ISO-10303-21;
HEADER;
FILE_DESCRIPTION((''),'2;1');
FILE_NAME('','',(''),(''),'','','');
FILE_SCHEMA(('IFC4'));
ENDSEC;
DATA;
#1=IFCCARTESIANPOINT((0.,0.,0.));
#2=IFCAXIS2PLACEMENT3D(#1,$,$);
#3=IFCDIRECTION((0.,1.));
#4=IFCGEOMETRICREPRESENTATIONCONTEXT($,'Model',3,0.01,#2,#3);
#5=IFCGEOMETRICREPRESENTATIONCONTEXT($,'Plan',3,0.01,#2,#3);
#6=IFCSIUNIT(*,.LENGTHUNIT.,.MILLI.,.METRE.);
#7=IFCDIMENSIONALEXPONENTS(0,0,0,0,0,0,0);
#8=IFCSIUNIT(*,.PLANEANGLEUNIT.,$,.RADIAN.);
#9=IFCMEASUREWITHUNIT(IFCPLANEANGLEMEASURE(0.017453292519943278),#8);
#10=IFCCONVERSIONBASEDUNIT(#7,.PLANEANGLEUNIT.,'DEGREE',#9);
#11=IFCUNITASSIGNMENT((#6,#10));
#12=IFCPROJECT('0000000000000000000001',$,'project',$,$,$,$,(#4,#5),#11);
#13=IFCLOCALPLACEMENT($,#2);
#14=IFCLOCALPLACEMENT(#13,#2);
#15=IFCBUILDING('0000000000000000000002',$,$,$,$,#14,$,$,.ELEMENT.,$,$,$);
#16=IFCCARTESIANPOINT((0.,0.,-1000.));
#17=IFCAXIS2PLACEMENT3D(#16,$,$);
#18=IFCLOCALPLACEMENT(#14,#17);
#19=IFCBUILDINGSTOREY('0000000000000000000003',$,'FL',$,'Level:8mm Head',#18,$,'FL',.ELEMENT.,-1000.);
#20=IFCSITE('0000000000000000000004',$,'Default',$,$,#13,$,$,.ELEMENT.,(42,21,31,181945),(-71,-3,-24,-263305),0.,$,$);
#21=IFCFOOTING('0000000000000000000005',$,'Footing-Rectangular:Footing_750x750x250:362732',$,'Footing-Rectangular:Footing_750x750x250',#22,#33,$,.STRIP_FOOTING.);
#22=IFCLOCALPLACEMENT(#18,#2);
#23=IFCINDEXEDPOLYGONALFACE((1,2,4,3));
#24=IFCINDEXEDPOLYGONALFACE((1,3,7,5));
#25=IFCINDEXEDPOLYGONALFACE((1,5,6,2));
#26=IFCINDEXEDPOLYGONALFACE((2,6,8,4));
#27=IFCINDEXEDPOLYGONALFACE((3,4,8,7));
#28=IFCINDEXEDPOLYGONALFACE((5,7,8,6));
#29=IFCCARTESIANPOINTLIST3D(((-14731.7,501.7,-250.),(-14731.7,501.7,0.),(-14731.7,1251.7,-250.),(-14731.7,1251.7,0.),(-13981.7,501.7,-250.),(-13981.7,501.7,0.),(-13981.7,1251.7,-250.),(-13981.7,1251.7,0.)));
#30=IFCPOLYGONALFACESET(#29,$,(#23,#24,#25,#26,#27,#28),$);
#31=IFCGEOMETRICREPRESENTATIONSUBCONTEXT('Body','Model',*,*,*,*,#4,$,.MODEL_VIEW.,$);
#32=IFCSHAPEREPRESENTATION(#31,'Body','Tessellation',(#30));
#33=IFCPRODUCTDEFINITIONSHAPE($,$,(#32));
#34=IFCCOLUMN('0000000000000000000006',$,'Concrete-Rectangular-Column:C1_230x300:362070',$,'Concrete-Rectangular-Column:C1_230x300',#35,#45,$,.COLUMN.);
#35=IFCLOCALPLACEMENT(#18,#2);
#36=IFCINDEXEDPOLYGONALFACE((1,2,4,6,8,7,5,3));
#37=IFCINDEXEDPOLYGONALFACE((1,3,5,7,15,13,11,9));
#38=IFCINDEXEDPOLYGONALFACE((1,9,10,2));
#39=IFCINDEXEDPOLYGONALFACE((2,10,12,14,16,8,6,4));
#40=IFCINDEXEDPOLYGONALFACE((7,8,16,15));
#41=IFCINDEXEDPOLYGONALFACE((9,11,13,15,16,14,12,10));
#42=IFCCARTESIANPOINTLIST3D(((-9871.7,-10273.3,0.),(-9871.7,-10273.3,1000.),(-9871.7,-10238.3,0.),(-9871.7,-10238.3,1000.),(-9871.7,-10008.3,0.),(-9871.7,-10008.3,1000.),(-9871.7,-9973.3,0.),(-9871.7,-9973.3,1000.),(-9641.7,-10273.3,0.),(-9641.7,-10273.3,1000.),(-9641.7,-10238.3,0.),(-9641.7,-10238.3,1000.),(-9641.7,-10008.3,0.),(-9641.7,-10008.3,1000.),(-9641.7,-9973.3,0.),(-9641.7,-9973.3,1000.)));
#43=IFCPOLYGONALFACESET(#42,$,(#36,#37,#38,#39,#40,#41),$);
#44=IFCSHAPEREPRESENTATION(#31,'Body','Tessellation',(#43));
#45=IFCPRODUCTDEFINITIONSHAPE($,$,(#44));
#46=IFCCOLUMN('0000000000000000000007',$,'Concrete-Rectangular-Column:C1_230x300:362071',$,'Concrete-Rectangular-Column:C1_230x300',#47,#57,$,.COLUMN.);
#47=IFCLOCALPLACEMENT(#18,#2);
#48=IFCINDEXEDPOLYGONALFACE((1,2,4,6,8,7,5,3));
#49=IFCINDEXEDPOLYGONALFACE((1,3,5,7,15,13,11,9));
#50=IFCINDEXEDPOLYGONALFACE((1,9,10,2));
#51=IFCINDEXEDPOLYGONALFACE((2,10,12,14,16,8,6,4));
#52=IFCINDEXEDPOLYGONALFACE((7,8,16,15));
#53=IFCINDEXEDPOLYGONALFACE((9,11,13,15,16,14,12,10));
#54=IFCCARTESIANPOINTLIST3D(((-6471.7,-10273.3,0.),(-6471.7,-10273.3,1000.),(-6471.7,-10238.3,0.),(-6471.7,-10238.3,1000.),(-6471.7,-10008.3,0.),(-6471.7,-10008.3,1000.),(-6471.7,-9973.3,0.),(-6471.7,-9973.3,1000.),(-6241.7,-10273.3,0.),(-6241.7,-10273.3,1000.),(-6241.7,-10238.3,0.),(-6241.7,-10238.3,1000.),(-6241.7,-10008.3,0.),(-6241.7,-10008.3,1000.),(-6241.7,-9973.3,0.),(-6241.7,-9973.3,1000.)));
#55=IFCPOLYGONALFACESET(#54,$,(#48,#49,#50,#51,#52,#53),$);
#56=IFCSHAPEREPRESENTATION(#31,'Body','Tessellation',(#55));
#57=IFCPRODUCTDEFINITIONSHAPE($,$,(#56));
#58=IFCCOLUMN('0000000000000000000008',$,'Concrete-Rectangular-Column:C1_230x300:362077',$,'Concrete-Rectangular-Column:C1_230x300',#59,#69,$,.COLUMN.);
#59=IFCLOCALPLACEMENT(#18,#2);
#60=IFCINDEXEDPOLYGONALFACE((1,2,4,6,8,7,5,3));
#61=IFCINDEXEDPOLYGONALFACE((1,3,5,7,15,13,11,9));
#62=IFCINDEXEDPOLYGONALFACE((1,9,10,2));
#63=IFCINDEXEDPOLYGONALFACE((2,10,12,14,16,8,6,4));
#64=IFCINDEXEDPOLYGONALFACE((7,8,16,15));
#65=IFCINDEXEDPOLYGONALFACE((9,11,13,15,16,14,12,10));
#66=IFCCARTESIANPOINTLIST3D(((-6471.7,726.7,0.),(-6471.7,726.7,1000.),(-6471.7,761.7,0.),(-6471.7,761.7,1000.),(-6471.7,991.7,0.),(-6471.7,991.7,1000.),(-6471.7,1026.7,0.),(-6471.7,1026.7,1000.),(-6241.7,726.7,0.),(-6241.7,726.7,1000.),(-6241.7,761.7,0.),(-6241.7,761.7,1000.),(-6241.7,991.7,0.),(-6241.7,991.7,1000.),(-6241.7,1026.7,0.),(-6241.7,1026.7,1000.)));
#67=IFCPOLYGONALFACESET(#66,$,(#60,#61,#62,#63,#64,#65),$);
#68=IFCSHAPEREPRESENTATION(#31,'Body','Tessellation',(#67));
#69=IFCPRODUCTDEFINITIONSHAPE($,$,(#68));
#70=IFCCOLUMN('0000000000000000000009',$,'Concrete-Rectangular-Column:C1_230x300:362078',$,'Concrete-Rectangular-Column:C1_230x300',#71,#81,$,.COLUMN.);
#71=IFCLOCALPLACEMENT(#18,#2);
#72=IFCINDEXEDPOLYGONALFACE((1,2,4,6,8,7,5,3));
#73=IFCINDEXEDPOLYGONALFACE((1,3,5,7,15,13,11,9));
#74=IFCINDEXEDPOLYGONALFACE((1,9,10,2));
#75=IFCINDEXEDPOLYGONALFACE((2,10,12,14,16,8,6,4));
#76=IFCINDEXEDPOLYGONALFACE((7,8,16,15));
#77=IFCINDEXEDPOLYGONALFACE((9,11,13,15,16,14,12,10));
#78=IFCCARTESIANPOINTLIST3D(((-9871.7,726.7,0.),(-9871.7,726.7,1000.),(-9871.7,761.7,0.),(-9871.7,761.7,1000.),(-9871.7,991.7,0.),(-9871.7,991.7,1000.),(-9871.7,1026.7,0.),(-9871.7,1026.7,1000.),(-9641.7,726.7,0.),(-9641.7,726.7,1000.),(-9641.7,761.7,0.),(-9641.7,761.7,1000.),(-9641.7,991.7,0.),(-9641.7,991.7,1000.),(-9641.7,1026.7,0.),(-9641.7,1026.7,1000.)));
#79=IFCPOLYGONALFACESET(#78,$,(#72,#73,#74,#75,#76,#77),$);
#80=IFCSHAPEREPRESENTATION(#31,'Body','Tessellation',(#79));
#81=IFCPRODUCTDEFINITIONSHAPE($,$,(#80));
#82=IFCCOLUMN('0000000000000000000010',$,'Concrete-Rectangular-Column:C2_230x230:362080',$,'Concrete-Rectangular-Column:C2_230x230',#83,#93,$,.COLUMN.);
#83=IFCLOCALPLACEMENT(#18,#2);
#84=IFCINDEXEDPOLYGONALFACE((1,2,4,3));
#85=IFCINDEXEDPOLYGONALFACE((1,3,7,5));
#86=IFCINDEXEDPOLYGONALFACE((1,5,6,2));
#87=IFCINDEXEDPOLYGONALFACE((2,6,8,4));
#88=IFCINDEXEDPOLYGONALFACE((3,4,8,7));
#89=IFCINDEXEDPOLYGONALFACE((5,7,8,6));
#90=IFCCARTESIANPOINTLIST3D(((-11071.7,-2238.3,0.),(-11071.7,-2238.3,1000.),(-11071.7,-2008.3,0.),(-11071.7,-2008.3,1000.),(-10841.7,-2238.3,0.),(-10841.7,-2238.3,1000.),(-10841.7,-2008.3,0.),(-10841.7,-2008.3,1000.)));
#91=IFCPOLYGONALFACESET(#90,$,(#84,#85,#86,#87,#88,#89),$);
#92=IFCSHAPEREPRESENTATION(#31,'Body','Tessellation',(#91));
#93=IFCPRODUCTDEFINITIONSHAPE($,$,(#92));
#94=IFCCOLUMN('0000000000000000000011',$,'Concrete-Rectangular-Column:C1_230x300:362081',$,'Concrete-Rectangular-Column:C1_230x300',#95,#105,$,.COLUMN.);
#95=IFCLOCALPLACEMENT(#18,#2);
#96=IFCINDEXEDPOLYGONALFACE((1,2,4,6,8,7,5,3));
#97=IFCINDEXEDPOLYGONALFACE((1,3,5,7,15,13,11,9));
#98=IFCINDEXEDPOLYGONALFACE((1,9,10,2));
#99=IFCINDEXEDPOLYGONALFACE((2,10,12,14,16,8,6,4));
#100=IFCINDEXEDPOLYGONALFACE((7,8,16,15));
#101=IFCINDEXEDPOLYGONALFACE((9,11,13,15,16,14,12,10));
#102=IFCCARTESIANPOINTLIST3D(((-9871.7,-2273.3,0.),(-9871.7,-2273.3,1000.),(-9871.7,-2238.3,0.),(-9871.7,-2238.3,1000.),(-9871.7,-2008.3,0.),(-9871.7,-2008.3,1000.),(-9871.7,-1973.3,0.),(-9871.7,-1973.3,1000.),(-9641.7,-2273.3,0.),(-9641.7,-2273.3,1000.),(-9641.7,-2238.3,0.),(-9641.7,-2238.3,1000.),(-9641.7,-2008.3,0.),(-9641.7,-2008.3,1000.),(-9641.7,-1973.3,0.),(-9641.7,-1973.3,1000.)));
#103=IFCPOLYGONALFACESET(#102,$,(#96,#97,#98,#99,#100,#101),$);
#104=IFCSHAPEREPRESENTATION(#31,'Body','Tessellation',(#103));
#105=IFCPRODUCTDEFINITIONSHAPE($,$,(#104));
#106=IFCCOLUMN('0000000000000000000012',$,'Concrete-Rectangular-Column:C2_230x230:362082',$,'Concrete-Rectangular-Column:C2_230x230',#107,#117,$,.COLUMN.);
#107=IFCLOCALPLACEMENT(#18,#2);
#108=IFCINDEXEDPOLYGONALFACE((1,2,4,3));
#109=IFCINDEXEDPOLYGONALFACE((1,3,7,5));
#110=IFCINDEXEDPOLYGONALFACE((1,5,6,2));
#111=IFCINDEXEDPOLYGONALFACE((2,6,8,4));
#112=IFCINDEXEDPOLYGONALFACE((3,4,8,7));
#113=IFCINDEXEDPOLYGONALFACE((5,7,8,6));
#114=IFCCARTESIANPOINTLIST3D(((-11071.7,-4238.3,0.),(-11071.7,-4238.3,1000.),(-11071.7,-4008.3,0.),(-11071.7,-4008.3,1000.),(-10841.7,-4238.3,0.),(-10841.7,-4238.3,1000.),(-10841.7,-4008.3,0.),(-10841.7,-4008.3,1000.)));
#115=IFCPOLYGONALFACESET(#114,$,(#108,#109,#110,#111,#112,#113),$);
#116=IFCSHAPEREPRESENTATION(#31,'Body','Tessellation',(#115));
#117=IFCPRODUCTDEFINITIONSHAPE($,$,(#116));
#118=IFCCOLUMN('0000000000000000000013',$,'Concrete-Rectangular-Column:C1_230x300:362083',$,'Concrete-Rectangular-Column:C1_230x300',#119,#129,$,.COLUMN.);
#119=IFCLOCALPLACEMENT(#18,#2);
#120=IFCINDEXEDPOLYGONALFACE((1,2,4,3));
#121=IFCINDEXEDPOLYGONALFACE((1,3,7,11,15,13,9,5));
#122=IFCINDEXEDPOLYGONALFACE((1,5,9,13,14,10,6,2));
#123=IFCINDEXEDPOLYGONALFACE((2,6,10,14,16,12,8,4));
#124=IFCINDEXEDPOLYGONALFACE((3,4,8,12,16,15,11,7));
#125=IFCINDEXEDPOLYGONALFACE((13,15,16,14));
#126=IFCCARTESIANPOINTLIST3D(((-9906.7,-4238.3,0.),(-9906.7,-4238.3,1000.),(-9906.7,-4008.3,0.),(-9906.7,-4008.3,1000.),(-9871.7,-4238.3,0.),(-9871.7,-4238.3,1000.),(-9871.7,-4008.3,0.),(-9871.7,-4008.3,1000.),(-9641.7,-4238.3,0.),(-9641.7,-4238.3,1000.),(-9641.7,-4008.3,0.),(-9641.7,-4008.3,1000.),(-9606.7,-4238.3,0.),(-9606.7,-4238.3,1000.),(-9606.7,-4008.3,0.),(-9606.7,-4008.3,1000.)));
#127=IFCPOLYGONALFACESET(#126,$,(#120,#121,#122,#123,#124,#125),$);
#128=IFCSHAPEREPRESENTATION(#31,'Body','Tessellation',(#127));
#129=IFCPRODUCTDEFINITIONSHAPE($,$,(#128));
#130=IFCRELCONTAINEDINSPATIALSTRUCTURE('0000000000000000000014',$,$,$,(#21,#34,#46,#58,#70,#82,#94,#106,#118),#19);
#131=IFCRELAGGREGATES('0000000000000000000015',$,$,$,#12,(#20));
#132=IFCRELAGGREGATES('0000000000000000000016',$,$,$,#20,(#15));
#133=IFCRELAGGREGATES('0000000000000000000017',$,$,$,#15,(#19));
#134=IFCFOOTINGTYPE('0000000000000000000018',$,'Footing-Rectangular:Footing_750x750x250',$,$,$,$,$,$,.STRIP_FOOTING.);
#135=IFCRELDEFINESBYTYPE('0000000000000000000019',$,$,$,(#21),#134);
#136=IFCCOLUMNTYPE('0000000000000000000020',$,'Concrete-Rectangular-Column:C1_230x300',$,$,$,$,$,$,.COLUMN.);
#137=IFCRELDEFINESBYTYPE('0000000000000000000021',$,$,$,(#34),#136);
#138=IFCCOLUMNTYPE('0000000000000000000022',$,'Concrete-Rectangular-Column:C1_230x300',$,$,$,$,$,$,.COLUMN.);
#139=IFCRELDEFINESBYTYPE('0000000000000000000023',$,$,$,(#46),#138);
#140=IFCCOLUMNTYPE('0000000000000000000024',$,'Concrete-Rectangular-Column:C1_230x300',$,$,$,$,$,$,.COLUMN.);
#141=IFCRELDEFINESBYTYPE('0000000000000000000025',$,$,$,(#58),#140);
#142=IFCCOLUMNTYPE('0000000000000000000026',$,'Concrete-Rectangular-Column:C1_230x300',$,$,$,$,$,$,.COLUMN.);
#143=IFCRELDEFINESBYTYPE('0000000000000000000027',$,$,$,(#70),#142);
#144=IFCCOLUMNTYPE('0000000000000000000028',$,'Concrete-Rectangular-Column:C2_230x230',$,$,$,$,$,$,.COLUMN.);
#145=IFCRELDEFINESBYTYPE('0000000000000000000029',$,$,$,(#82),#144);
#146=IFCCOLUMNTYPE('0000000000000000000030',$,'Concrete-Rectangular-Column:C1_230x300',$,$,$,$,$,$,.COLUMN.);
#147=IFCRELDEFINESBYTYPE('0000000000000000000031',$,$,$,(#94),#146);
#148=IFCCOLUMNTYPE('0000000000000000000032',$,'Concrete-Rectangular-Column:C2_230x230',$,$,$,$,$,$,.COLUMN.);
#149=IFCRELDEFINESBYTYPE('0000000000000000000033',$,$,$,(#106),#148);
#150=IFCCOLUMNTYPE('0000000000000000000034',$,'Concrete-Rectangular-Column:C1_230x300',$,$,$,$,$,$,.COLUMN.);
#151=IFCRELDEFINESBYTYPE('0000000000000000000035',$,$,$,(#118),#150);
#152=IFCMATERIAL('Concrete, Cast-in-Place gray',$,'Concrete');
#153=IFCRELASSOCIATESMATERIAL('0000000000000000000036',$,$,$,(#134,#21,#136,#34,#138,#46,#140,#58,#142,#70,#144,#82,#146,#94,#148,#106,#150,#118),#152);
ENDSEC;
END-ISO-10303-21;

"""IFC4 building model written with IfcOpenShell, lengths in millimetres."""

from ifc_helpers import new_model, entity, si_unit, converted_unit, direction, frame, origin, place, context, subcontext, project, spatial, indexed_curve, outline, extrude, source, transform, mapped, material, type_object, type_shapes, element, save


model = new_model("IFC4")

# Units and contexts
model_context = context("Model", 3, precision=0.01, world=origin(), true_north=direction((0.0, 1.0)))
plan_context = context("Plan", 3, precision=0.01, world=origin(), true_north=direction((0.0, 1.0)))
body_context = subcontext(model_context, "Body", "Model", "MODEL_VIEW")
ifc_project = project(units=[si_unit("LENGTHUNIT", "METRE", prefix="MILLI"), converted_unit("PLANEANGLEUNIT", "DEGREE", entity("IfcPlaneAngleMeasure", 0.017453292519943278), si_unit("PLANEANGLEUNIT", "RADIAN"), dimensions=[0, 0, 0, 0, 0, 0, 0])], contexts=[model_context, plan_context])

# Site, building, storey
site_placement = place(None, origin())
site = spatial("IfcSite", under=ifc_project, at=site_placement, Name="Default", CompositionType="ELEMENT", RefLatitude=(42, 21, 31, 181945), RefLongitude=(-71, -3, -24, -263305), RefElevation=0.0)
building_placement = place(site_placement, origin())
building = spatial("IfcBuilding", under=site, at=building_placement, CompositionType="ELEMENT")
storey_placement = place(building_placement, frame((0.0, 0.0, -1000.0)))
storey = spatial("IfcBuildingStorey", under=building, at=storey_placement, Name="FL", ObjectType="Level:8mm Head", LongName="FL", CompositionType="ELEMENT", Elevation=-1000.0)

# Footing
ifc_material_1 = material(Name="Concrete, Cast-in-Place gray", Category="Concrete")
footing_type = type_object("IfcFootingType", Name="Footing-Rectangular:Footing_750x750x250", PredefinedType="STRIP_FOOTING", material=ifc_material_1)
shared_shape_1 = source(origin(), body_context, "Body", "SweptSolid", [
    extrude(outline(indexed_curve([(-375.0, -375.0), (375.0, -375.0), (375.0, 375.0), (-375.0, 375.0), (-375.0, -375.0)], self_intersect=False)), frame((-14356.7, 876.7, -1250.0), z_axis=(0.0, 0.0, 1.0), x_axis=(-1.0, 0.0, 0.0)), (0.0, 0.0, 1.0), 250.0),
])
type_shapes(footing_type, [shared_shape_1])
footing_placement = place(storey_placement, frame((0.0, 0.0, 1000.0)))
element("IfcFooting", 1, at=footing_placement, inside=storey, type_object=footing_type, material=ifc_material_1, Name="Footing-Rectangular:Footing_750x750x250:362732", ObjectType="Footing-Rectangular:Footing_750x750x250", PredefinedType="STRIP_FOOTING", context=body_context, shape_type="MappedRepresentation", body=[
    mapped(shared_shape_1, transform((0.0, 0.0, 0.0), scale=1.0)),
])

# Columns
column_type_1 = type_object("IfcColumnType", Name="Concrete-Rectangular-Column:C1_230x300", PredefinedType="COLUMN", material=ifc_material_1)
shared_shape_2 = source(origin(), body_context, "Body", "SweptSolid", [
    extrude(outline(indexed_curve([(-115.0, -150.0), (115.0, -150.0), (115.0, -115.0), (115.0, 115.0), (115.0, 150.0), (-115.0, 150.0), (-115.0, 115.0), (-115.0, -115.0), (-115.0, -150.0)], self_intersect=False)), frame((-9756.7, -10123.3, -1000.0)), (0.0, 0.0, 1.0), 1000.0),
])
type_shapes(column_type_1, [shared_shape_2])
column_1_placement = place(storey_placement, frame((0.0, 0.0, 1000.0)))
element("IfcColumn", 2, at=column_1_placement, inside=storey, type_object=column_type_1, material=ifc_material_1, Name="Concrete-Rectangular-Column:C1_230x300:362070", ObjectType="Concrete-Rectangular-Column:C1_230x300", PredefinedType="COLUMN", context=body_context, shape_type="MappedRepresentation", body=[
    mapped(shared_shape_2, transform((0.0, 0.0, 0.0), scale=1.0)),
])
column_type_2 = type_object("IfcColumnType", Name="Concrete-Rectangular-Column:C1_230x300", PredefinedType="COLUMN", material=ifc_material_1)
shared_shape_3 = source(origin(), body_context, "Body", "SweptSolid", [
    extrude(outline(indexed_curve([(-115.0, -150.0), (115.0, -150.0), (115.0, -115.0), (115.0, 115.0), (115.0, 150.0), (-115.0, 150.0), (-115.0, 115.0), (-115.0, -115.0), (-115.0, -150.0)], self_intersect=False)), frame((-6356.7, -10123.3, -1000.0)), (0.0, 0.0, 1.0), 1000.0),
])
type_shapes(column_type_2, [shared_shape_3])
column_2_placement = place(storey_placement, frame((0.0, 0.0, 1000.0)))
element("IfcColumn", 3, at=column_2_placement, inside=storey, type_object=column_type_2, material=ifc_material_1, Name="Concrete-Rectangular-Column:C1_230x300:362071", ObjectType="Concrete-Rectangular-Column:C1_230x300", PredefinedType="COLUMN", context=body_context, shape_type="MappedRepresentation", body=[
    mapped(shared_shape_3, transform((0.0, 0.0, 0.0), scale=1.0)),
])
column_type_3 = type_object("IfcColumnType", Name="Concrete-Rectangular-Column:C1_230x300", PredefinedType="COLUMN", material=ifc_material_1)
shared_shape_4 = source(origin(), body_context, "Body", "SweptSolid", [
    extrude(outline(indexed_curve([(-115.0, -150.0), (115.0, -150.0), (115.0, -115.0), (115.0, 115.0), (115.0, 150.0), (-115.0, 150.0), (-115.0, 115.0), (-115.0, -115.0), (-115.0, -150.0)], self_intersect=False)), frame((-6356.7, 876.7, -1000.0), z_axis=(0.0, 0.0, 1.0), x_axis=(-1.0, 0.0, 0.0)), (0.0, 0.0, 1.0), 1000.0),
])
type_shapes(column_type_3, [shared_shape_4])
column_3_placement = place(storey_placement, frame((0.0, 0.0, 1000.0)))
element("IfcColumn", 4, at=column_3_placement, inside=storey, type_object=column_type_3, material=ifc_material_1, Name="Concrete-Rectangular-Column:C1_230x300:362077", ObjectType="Concrete-Rectangular-Column:C1_230x300", PredefinedType="COLUMN", context=body_context, shape_type="MappedRepresentation", body=[
    mapped(shared_shape_4, transform((0.0, 0.0, 0.0), scale=1.0)),
])
column_type_4 = type_object("IfcColumnType", Name="Concrete-Rectangular-Column:C1_230x300", PredefinedType="COLUMN", material=ifc_material_1)
shared_shape_5 = source(origin(), body_context, "Body", "SweptSolid", [
    extrude(outline(indexed_curve([(-115.0, -150.0), (115.0, -150.0), (115.0, -115.0), (115.0, 115.0), (115.0, 150.0), (-115.0, 150.0), (-115.0, 115.0), (-115.0, -115.0), (-115.0, -150.0)], self_intersect=False)), frame((-9756.7, 876.7, -1000.0), z_axis=(0.0, 0.0, 1.0), x_axis=(-1.0, 0.0, 0.0)), (0.0, 0.0, 1.0), 1000.0),
])
type_shapes(column_type_4, [shared_shape_5])
column_4_placement = place(storey_placement, frame((0.0, 0.0, 1000.0)))
element("IfcColumn", 5, at=column_4_placement, inside=storey, type_object=column_type_4, material=ifc_material_1, Name="Concrete-Rectangular-Column:C1_230x300:362078", ObjectType="Concrete-Rectangular-Column:C1_230x300", PredefinedType="COLUMN", context=body_context, shape_type="MappedRepresentation", body=[
    mapped(shared_shape_5, transform((0.0, 0.0, 0.0), scale=1.0)),
])
column_type_5 = type_object("IfcColumnType", Name="Concrete-Rectangular-Column:C2_230x230", PredefinedType="COLUMN", material=ifc_material_1)
shared_shape_6 = source(origin(), body_context, "Body", "SweptSolid", [
    extrude(outline(indexed_curve([(-115.0, -115.0), (115.0, -115.0), (115.0, 115.0), (-115.0, 115.0), (-115.0, -115.0)], self_intersect=False)), frame((-10956.7, -2123.3, -1000.0), z_axis=(0.0, 0.0, 1.0), x_axis=(0.0, -1.0, 0.0)), (0.0, 0.0, 1.0), 1000.0),
])
type_shapes(column_type_5, [shared_shape_6])
column_5_placement = place(storey_placement, frame((0.0, 0.0, 1000.0)))
element("IfcColumn", 6, at=column_5_placement, inside=storey, type_object=column_type_5, material=ifc_material_1, Name="Concrete-Rectangular-Column:C2_230x230:362080", ObjectType="Concrete-Rectangular-Column:C2_230x230", PredefinedType="COLUMN", context=body_context, shape_type="MappedRepresentation", body=[
    mapped(shared_shape_6, transform((0.0, 0.0, 0.0), scale=1.0)),
])
column_type_6 = type_object("IfcColumnType", Name="Concrete-Rectangular-Column:C1_230x300", PredefinedType="COLUMN", material=ifc_material_1)
shared_shape_7 = source(origin(), body_context, "Body", "SweptSolid", [
    extrude(outline(indexed_curve([(-115.0, -150.0), (115.0, -150.0), (115.0, -115.0), (115.0, 115.0), (115.0, 150.0), (-115.0, 150.0), (-115.0, 115.0), (-115.0, -115.0), (-115.0, -150.0)], self_intersect=False)), frame((-9756.7, -2123.3, -1000.0)), (0.0, 0.0, 1.0), 1000.0),
])
type_shapes(column_type_6, [shared_shape_7])
column_6_placement = place(storey_placement, frame((0.0, 0.0, 1000.0)))
element("IfcColumn", 7, at=column_6_placement, inside=storey, type_object=column_type_6, material=ifc_material_1, Name="Concrete-Rectangular-Column:C1_230x300:362081", ObjectType="Concrete-Rectangular-Column:C1_230x300", PredefinedType="COLUMN", context=body_context, shape_type="MappedRepresentation", body=[
    mapped(shared_shape_7, transform((0.0, 0.0, 0.0), scale=1.0)),
])
column_type_7 = type_object("IfcColumnType", Name="Concrete-Rectangular-Column:C2_230x230", PredefinedType="COLUMN", material=ifc_material_1)
shared_shape_8 = source(origin(), body_context, "Body", "SweptSolid", [
    extrude(outline(indexed_curve([(-115.0, -115.0), (115.0, -115.0), (115.0, 115.0), (-115.0, 115.0), (-115.0, -115.0)], self_intersect=False)), frame((-10956.7, -4123.3, -1000.0), z_axis=(0.0, 0.0, 1.0), x_axis=(0.0, 1.0, 0.0)), (0.0, 0.0, 1.0), 1000.0),
])
type_shapes(column_type_7, [shared_shape_8])
column_7_placement = place(storey_placement, frame((0.0, 0.0, 1000.0)))
element("IfcColumn", 8, at=column_7_placement, inside=storey, type_object=column_type_7, material=ifc_material_1, Name="Concrete-Rectangular-Column:C2_230x230:362082", ObjectType="Concrete-Rectangular-Column:C2_230x230", PredefinedType="COLUMN", context=body_context, shape_type="MappedRepresentation", body=[
    mapped(shared_shape_8, transform((0.0, 0.0, 0.0), scale=1.0)),
])
column_type_8 = type_object("IfcColumnType", Name="Concrete-Rectangular-Column:C1_230x300", PredefinedType="COLUMN", material=ifc_material_1)
shared_shape_9 = source(origin(), body_context, "Body", "SweptSolid", [
    extrude(outline(indexed_curve([(-115.0, -150.0), (115.0, -150.0), (115.0, -115.0), (115.0, 115.0), (115.0, 150.0), (-115.0, 150.0), (-115.0, 115.0), (-115.0, -115.0), (-115.0, -150.0)], self_intersect=False)), frame((-9756.7, -4123.3, -1000.0), z_axis=(0.0, 0.0, 1.0), x_axis=(0.0, 1.0, 0.0)), (0.0, 0.0, 1.0), 1000.0),
])
type_shapes(column_type_8, [shared_shape_9])
column_8_placement = place(storey_placement, frame((0.0, 0.0, 1000.0)))
element("IfcColumn", 9, at=column_8_placement, inside=storey, type_object=column_type_8, material=ifc_material_1, Name="Concrete-Rectangular-Column:C1_230x300:362083", ObjectType="Concrete-Rectangular-Column:C1_230x300", PredefinedType="COLUMN", context=body_context, shape_type="MappedRepresentation", body=[
    mapped(shared_shape_9, transform((0.0, 0.0, 0.0), scale=1.0)),
])

save(model, "model.ifc")
